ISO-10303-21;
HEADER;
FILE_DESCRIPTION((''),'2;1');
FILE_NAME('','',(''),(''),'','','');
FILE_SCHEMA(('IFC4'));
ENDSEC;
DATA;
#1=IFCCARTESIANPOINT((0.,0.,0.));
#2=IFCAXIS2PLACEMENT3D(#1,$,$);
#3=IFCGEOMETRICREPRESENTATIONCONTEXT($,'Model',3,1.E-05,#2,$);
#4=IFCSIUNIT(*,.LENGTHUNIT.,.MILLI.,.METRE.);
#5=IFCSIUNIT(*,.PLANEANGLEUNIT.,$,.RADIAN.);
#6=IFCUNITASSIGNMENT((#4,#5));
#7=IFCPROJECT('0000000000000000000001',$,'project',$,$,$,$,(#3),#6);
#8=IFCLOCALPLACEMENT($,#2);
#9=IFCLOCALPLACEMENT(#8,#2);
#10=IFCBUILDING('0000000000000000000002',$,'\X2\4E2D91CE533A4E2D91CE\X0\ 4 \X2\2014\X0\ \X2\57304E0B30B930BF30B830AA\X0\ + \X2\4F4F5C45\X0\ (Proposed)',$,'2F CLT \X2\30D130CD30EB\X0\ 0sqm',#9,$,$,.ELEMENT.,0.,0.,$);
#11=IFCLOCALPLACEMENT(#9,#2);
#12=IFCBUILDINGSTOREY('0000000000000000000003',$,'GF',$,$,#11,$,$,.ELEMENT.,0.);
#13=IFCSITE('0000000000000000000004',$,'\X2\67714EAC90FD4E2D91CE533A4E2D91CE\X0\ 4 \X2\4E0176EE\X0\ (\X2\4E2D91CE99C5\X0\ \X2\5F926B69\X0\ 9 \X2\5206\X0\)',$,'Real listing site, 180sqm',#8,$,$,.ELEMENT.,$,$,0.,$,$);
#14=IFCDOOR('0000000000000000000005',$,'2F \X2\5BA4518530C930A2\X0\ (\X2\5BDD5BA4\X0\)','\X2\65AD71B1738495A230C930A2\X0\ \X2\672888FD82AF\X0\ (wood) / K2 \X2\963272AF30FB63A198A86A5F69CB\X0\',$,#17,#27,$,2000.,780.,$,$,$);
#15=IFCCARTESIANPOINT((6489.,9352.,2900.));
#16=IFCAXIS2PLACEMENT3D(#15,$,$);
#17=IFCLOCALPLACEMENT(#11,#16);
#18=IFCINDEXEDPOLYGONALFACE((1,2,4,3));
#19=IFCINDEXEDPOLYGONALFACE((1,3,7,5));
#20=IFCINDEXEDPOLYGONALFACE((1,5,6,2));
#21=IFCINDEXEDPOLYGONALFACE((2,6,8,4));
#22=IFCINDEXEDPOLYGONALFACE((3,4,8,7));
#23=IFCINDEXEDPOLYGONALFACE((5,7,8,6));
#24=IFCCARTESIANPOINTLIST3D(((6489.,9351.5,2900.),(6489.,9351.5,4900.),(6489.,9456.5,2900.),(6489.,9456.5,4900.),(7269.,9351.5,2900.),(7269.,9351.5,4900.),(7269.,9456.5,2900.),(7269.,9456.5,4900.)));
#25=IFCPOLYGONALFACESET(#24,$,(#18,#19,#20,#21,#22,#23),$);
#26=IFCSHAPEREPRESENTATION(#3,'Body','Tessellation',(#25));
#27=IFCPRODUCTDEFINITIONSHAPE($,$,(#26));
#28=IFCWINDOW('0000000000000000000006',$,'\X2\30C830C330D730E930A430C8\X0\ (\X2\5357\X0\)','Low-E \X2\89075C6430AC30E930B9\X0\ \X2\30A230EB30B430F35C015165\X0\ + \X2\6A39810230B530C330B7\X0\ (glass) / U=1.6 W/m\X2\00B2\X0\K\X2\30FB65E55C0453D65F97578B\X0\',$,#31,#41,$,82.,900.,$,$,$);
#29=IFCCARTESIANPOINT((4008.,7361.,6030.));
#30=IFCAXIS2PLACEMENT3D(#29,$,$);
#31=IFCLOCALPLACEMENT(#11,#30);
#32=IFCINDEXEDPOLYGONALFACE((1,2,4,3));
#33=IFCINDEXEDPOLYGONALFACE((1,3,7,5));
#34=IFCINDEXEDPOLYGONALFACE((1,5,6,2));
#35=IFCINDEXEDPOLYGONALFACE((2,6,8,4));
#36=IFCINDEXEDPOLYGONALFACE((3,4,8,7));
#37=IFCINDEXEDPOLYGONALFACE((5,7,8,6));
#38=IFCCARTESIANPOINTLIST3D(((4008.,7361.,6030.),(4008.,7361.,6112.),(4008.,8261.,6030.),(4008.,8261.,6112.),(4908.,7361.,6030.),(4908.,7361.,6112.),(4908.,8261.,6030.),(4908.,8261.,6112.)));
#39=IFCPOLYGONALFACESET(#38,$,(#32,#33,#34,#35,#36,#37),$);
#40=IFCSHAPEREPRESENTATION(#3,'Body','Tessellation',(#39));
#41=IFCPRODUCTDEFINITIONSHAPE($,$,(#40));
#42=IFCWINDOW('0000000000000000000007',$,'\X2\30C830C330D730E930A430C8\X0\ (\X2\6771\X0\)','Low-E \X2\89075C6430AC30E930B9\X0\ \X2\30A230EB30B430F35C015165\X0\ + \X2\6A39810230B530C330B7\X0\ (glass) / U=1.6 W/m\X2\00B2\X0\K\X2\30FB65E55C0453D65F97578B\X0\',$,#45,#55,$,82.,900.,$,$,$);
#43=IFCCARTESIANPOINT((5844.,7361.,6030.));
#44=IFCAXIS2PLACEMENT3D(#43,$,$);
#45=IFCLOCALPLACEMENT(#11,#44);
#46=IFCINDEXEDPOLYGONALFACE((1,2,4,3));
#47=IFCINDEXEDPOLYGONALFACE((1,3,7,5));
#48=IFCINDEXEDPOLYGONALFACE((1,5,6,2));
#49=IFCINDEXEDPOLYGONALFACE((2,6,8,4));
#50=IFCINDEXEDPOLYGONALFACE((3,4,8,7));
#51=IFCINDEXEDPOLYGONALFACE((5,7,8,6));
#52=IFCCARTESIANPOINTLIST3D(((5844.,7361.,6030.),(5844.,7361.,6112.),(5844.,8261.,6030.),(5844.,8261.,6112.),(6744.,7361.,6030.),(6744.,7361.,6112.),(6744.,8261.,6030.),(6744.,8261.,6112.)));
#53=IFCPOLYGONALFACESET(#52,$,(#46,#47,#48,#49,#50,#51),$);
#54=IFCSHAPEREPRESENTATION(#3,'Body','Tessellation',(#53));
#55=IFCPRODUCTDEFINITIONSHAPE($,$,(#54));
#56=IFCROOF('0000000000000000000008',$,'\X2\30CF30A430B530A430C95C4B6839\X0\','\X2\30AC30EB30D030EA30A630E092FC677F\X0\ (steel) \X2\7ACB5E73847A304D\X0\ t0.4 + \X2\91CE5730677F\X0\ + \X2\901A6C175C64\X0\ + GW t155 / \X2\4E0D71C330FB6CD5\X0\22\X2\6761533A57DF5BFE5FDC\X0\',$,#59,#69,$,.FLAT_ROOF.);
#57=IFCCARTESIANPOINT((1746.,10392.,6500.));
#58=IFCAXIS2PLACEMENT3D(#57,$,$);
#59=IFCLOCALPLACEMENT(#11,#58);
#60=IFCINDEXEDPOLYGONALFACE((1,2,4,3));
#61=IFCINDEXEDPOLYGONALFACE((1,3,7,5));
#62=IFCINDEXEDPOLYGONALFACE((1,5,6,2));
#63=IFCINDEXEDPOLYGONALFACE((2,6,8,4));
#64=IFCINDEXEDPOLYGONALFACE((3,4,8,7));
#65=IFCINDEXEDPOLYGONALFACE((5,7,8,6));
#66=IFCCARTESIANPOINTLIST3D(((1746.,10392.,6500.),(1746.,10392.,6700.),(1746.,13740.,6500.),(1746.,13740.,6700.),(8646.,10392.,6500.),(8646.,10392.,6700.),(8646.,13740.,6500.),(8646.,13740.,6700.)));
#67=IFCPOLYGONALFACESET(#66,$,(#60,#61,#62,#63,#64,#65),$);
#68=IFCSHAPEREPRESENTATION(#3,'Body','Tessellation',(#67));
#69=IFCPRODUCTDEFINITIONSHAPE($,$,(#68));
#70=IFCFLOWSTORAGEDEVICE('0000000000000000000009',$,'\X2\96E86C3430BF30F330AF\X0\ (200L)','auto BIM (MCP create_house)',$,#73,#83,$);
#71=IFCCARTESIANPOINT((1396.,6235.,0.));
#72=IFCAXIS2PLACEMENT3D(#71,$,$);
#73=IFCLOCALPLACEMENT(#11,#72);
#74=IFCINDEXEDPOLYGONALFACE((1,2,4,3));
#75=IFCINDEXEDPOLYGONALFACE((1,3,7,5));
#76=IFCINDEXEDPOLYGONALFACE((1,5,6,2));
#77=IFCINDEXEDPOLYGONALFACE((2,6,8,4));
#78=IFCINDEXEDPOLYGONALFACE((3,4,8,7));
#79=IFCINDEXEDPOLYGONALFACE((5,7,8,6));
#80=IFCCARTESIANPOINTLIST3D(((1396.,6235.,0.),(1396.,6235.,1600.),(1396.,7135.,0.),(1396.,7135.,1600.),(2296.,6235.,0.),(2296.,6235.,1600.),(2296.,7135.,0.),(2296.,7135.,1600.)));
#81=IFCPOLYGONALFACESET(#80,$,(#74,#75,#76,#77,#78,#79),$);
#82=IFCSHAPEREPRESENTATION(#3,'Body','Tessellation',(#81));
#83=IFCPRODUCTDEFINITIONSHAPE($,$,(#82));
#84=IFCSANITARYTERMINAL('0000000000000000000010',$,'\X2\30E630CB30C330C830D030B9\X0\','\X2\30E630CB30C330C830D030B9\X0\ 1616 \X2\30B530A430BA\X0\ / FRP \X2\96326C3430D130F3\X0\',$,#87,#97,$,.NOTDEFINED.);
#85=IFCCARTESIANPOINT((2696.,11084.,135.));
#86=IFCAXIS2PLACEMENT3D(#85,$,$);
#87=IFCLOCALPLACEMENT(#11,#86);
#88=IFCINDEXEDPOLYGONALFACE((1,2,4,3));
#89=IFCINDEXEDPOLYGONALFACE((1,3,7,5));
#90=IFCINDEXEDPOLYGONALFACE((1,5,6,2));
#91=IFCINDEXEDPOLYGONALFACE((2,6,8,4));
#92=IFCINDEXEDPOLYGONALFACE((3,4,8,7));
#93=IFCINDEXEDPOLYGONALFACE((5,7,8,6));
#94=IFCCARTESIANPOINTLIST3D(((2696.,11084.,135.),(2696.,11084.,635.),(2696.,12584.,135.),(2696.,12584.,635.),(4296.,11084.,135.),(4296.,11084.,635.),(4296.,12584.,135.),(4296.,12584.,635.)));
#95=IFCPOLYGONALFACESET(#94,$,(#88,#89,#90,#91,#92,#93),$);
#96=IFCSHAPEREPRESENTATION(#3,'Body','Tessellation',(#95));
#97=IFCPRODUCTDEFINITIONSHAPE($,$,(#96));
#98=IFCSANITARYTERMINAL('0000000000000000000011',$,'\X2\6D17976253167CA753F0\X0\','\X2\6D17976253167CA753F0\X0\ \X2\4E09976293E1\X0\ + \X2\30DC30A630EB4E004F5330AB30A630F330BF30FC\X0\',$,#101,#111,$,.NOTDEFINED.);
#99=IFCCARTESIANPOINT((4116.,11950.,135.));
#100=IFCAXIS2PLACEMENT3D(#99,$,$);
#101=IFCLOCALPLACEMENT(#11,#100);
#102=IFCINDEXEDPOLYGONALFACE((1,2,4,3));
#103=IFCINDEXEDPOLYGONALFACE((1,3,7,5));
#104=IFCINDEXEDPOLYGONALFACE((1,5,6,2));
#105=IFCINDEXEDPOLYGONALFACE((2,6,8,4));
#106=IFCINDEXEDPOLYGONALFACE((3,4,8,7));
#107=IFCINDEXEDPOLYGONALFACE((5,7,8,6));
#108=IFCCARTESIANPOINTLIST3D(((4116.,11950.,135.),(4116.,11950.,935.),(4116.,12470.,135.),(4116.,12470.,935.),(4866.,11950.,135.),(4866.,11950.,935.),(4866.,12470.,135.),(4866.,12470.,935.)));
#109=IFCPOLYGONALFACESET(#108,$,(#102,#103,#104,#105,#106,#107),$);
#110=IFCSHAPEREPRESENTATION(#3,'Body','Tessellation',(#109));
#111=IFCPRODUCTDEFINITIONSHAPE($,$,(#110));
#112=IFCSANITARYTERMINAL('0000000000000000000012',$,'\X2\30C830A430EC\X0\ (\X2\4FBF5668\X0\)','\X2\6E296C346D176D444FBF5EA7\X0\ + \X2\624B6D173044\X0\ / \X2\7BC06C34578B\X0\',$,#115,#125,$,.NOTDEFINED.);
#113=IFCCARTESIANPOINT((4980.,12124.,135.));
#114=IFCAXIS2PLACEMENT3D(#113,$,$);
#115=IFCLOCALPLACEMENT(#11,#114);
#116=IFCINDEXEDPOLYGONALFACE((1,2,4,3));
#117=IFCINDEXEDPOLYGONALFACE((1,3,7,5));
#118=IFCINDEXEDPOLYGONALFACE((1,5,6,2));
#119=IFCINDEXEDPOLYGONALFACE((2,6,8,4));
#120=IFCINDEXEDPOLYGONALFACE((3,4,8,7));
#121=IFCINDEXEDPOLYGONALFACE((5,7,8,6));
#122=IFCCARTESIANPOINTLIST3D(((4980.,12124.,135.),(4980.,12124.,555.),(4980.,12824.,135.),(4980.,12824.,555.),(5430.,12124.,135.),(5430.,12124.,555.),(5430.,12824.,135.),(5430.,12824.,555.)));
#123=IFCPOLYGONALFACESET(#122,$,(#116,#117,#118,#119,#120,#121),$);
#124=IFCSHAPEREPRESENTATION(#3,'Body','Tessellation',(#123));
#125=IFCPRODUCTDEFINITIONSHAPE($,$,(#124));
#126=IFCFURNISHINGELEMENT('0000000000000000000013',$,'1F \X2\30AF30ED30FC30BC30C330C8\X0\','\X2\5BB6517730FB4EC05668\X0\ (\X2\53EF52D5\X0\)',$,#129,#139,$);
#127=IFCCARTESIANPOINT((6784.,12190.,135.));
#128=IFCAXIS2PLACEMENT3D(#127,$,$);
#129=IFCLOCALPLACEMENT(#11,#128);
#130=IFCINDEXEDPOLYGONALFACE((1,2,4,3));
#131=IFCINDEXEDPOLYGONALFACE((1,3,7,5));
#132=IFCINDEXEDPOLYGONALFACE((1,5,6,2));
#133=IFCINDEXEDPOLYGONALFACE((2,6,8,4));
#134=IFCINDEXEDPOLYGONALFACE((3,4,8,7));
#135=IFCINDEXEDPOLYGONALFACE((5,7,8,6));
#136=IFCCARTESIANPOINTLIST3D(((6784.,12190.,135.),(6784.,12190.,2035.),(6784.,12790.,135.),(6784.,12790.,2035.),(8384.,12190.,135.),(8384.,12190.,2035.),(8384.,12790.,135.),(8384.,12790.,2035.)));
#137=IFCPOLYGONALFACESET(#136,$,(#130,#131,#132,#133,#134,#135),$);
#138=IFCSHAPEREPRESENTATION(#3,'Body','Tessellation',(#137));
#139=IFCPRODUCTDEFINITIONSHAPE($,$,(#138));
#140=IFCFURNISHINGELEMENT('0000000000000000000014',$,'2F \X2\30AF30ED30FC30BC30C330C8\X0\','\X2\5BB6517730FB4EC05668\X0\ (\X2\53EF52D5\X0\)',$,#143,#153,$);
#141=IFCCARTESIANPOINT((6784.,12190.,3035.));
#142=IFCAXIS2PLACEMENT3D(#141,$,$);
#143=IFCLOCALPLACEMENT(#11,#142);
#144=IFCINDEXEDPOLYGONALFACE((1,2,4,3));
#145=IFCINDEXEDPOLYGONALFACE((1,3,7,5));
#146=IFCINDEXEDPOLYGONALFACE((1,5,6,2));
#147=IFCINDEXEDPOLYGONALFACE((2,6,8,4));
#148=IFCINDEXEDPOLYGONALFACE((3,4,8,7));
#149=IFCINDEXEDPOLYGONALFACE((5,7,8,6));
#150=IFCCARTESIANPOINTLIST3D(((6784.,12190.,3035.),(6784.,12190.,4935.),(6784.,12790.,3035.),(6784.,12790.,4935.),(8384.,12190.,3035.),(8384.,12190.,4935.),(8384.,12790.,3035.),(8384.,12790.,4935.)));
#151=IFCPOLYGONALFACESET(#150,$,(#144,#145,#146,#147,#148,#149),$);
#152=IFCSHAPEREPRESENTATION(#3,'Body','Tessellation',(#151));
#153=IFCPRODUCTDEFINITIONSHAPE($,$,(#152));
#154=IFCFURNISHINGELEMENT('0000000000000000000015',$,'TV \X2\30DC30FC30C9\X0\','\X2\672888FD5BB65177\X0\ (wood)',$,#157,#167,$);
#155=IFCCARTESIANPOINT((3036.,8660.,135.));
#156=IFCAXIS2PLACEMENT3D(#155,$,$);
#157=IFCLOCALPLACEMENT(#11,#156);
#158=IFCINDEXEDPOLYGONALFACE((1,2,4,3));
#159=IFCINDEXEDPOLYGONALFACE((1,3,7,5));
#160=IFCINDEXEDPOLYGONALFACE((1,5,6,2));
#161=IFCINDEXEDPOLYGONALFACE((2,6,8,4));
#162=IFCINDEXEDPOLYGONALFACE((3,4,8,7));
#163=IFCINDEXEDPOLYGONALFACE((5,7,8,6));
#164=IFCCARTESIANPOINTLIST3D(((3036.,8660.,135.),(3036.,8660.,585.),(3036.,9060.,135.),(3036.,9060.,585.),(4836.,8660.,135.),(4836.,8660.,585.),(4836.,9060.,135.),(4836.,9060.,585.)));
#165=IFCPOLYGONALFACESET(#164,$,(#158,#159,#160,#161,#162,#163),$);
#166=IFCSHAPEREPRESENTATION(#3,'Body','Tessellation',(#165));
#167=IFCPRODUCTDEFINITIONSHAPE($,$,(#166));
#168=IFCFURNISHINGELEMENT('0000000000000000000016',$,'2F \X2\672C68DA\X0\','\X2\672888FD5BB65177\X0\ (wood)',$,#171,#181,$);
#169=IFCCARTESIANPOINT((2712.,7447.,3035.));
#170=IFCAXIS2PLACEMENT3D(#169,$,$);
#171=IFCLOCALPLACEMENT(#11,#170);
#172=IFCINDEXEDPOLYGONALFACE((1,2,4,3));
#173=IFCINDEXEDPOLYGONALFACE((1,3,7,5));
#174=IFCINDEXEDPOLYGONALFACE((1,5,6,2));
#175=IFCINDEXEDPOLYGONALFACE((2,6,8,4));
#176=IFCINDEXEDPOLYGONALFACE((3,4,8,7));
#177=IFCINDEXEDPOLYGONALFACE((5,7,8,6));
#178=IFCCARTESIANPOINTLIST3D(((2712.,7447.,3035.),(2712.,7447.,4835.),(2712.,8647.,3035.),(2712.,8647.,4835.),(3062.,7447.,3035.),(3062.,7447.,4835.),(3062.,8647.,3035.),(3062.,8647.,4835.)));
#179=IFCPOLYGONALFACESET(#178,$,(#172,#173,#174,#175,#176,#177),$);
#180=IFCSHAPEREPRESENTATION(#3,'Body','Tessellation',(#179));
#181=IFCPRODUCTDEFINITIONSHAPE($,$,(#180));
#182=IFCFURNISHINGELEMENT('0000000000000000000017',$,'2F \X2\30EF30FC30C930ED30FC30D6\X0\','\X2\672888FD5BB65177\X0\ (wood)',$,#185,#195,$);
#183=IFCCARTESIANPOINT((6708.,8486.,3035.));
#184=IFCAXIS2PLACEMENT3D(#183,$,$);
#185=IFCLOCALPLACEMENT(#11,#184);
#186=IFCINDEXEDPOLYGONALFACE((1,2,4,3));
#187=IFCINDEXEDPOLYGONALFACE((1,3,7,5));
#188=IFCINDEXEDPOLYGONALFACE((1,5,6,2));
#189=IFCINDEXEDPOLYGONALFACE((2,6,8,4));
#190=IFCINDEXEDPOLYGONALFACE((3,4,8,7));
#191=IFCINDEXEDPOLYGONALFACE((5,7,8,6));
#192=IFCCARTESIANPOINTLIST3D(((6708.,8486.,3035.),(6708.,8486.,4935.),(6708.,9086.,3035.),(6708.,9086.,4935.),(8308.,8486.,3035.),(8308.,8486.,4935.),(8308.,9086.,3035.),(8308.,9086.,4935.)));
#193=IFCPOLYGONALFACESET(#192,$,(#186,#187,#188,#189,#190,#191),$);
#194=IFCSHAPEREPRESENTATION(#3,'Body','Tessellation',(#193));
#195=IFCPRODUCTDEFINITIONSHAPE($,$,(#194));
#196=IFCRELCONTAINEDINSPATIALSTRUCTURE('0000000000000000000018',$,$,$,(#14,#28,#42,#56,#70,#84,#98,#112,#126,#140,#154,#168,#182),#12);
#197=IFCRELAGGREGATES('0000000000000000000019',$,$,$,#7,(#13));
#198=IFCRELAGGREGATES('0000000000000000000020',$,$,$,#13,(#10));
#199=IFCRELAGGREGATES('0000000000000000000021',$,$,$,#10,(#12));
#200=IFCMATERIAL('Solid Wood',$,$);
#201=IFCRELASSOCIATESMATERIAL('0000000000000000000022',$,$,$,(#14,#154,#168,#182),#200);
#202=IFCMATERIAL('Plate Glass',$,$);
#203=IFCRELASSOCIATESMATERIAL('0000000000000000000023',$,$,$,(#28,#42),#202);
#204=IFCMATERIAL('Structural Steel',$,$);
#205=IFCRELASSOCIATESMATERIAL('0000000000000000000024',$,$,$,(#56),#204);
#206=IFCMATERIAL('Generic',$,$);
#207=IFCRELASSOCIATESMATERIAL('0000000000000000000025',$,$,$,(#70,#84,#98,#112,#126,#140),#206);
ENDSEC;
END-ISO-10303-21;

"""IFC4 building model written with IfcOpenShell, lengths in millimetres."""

from ifc_helpers import new_model, si_unit, frame, frame_2d, origin, place, context, project, spatial, rectangle, extrude, material, element, save


model = new_model("IFC4")

# Units and contexts
model_context = context("Model", 3, precision=1e-05, world=origin())
ifc_project = project(units=[si_unit("LENGTHUNIT", "METRE", prefix="MILLI"), si_unit("PLANEANGLEUNIT", "RADIAN")], contexts=[model_context])

# Site, building, storey
site_placement = place(None, origin())
site = spatial("IfcSite", under=ifc_project, at=site_placement, Name="東京都中野区中野 4 丁目 (中野駅 徒歩 9 分)", ObjectType="Real listing site, 180sqm", CompositionType="ELEMENT", RefElevation=0.0)
building_placement = place(site_placement, origin())
building = spatial("IfcBuilding", under=site, at=building_placement, Name="中野区中野 4 — 地下スタジオ + 住居 (Proposed)", ObjectType="2F CLT パネル 0sqm", CompositionType="ELEMENT", ElevationOfRefHeight=0.0, ElevationOfTerrain=0.0)
storey_placement = place(building_placement, origin())
storey = spatial("IfcBuildingStorey", under=building, at=storey_placement, Name="GF", CompositionType="ELEMENT", Elevation=0.0)

# Shared definitions
ifc_material_1 = material(Name="Solid Wood")
ifc_material_2 = material(Name="Plate Glass")

# Door
door_1_placement = place(storey_placement, frame((6489.0, 9352.0, 2900.0)))
element("IfcDoor", 1, at=door_1_placement, inside=storey, material=ifc_material_1, Name="2F 室内ドア (寝室)", Description="断熱玄関ドア 木製芯 (wood) / K2 防犯・採風機構", OverallHeight=2000.0, OverallWidth=780.0, context=model_context, shape_type="SweptSolid", body=[
    extrude(rectangle(XDim=780.0, YDim=105.0, at=frame_2d((390.0, 52.0))), frame((6489.0, 9352.0, 2900.0)), (0.0, 0.0, 1.0), 2000.0),
])

# Windows
window_1_placement = place(storey_placement, frame((4008.0, 7361.0, 6030.0)))
element("IfcWindow", 2, at=window_1_placement, inside=storey, material=ifc_material_2, Name="トップライト (南)", Description="Low-E 複層ガラス アルゴン封入 + 樹脂サッシ (glass) / U=1.6 W/m²K・日射取得型", OverallHeight=82.0, OverallWidth=900.0, context=model_context, shape_type="SweptSolid", body=[
    extrude(rectangle(XDim=900.0, YDim=900.0, at=frame_2d((450.0, 450.0))), frame((4008.0, 7361.0, 6030.0)), (0.0, 0.0, 1.0), 82.0),
])
window_2_placement = place(storey_placement, frame((5844.0, 7361.0, 6030.0)))
element("IfcWindow", 3, at=window_2_placement, inside=storey, material=ifc_material_2, Name="トップライト (東)", Description="Low-E 複層ガラス アルゴン封入 + 樹脂サッシ (glass) / U=1.6 W/m²K・日射取得型", OverallHeight=82.0, OverallWidth=900.0, context=model_context, shape_type="SweptSolid", body=[
    extrude(rectangle(XDim=900.0, YDim=900.0, at=frame_2d((450.0, 450.0))), frame((5844.0, 7361.0, 6030.0)), (0.0, 0.0, 1.0), 82.0),
])

# Roof
ifc_material_3 = material(Name="Structural Steel")
roof_placement = place(storey_placement, frame((1746.0, 10392.0, 6500.0)))
element("IfcRoof", 4, at=roof_placement, inside=storey, material=ifc_material_3, Name="ハイサイド屋根", Description="ガルバリウム鋼板 (steel) 立平葺き t0.4 + 野地板 + 通気層 + GW t155 / 不燃・法22条区域対応", PredefinedType="FLAT_ROOF", context=model_context, shape_type="SweptSolid", body=[
    extrude(rectangle(XDim=6900.0, YDim=3348.0, at=frame_2d((3450.0, 1674.0))), frame((1746.0, 10392.0, 6500.0)), (0.0, 0.0, 1.0), 200.0),
])

# Flow storage device
ifc_material_4 = material(Name="Generic")
flow_storage_device_placement = place(storey_placement, frame((1396.0, 6235.0, 0.0)))
element("IfcFlowStorageDevice", 5, at=flow_storage_device_placement, inside=storey, material=ifc_material_4, Name="雨水タンク (200L)", Description="auto BIM (MCP create_house)", context=model_context, shape_type="SweptSolid", body=[
    extrude(rectangle(XDim=900.0, YDim=900.0, at=frame_2d((450.0, 450.0))), frame((1396.0, 6235.0, 0.0)), (0.0, 0.0, 1.0), 1600.0),
])

# Sanitary terminals
sanitary_terminal_1_placement = place(storey_placement, frame((2696.0, 11084.0, 135.0)))
element("IfcSanitaryTerminal", 6, at=sanitary_terminal_1_placement, inside=storey, material=ifc_material_4, Name="ユニットバス", Description="ユニットバス 1616 サイズ / FRP 防水パン", PredefinedType="NOTDEFINED", context=model_context, shape_type="SweptSolid", body=[
    extrude(rectangle(XDim=1600.0, YDim=1500.0, at=frame_2d((800.0, 750.0))), frame((2696.0, 11084.0, 135.0)), (0.0, 0.0, 1.0), 500.0),
])
sanitary_terminal_2_placement = place(storey_placement, frame((4116.0, 11950.0, 135.0)))
element("IfcSanitaryTerminal", 7, at=sanitary_terminal_2_placement, inside=storey, material=ifc_material_4, Name="洗面化粧台", Description="洗面化粧台 三面鏡 + ボウル一体カウンター", PredefinedType="NOTDEFINED", context=model_context, shape_type="SweptSolid", body=[
    extrude(rectangle(XDim=750.0, YDim=520.0, at=frame_2d((375.0, 260.0))), frame((4116.0, 11950.0, 135.0)), (0.0, 0.0, 1.0), 800.0),
])
sanitary_terminal_3_placement = place(storey_placement, frame((4980.0, 12124.0, 135.0)))
element("IfcSanitaryTerminal", 8, at=sanitary_terminal_3_placement, inside=storey, material=ifc_material_4, Name="トイレ (便器)", Description="温水洗浄便座 + 手洗い / 節水型", PredefinedType="NOTDEFINED", context=model_context, shape_type="SweptSolid", body=[
    extrude(rectangle(XDim=450.0, YDim=700.0, at=frame_2d((225.0, 350.0))), frame((4980.0, 12124.0, 135.0)), (0.0, 0.0, 1.0), 420.0),
])

# Furnishing elements
furnishing_1_placement = place(storey_placement, frame((6784.0, 12190.0, 135.0)))
element("IfcFurnishingElement", 9, at=furnishing_1_placement, inside=storey, material=ifc_material_4, Name="1F クローゼット", Description="家具・什器 (可動)", context=model_context, shape_type="SweptSolid", body=[
    extrude(rectangle(XDim=1600.0, YDim=600.0, at=frame_2d((800.0, 300.0))), frame((6784.0, 12190.0, 135.0)), (0.0, 0.0, 1.0), 1900.0),
])
furnishing_2_placement = place(storey_placement, frame((6784.0, 12190.0, 3035.0)))
element("IfcFurnishingElement", 10, at=furnishing_2_placement, inside=storey, material=ifc_material_4, Name="2F クローゼット", Description="家具・什器 (可動)", context=model_context, shape_type="SweptSolid", body=[
    extrude(rectangle(XDim=1600.0, YDim=600.0, at=frame_2d((800.0, 300.0))), frame((6784.0, 12190.0, 3035.0)), (0.0, 0.0, 1.0), 1900.0),
])
furnishing_3_placement = place(storey_placement, frame((3036.0, 8660.0, 135.0)))
element("IfcFurnishingElement", 11, at=furnishing_3_placement, inside=storey, material=ifc_material_1, Name="TV ボード", Description="木製家具 (wood)", context=model_context, shape_type="SweptSolid", body=[
    extrude(rectangle(XDim=1800.0, YDim=400.0, at=frame_2d((900.0, 200.0))), frame((3036.0, 8660.0, 135.0)), (0.0, 0.0, 1.0), 450.0),
])
furnishing_4_placement = place(storey_placement, frame((2712.0, 7447.0, 3035.0)))
element("IfcFurnishingElement", 12, at=furnishing_4_placement, inside=storey, material=ifc_material_1, Name="2F 本棚", Description="木製家具 (wood)", context=model_context, shape_type="SweptSolid", body=[
    extrude(rectangle(XDim=350.0, YDim=1200.0, at=frame_2d((175.0, 600.0))), frame((2712.0, 7447.0, 3035.0)), (0.0, 0.0, 1.0), 1800.0),
])
furnishing_5_placement = place(storey_placement, frame((6708.0, 8486.0, 3035.0)))
element("IfcFurnishingElement", 13, at=furnishing_5_placement, inside=storey, material=ifc_material_1, Name="2F ワードローブ", Description="木製家具 (wood)", context=model_context, shape_type="SweptSolid", body=[
    extrude(rectangle(XDim=1600.0, YDim=600.0, at=frame_2d((800.0, 300.0))), frame((6708.0, 8486.0, 3035.0)), (0.0, 0.0, 1.0), 1900.0),
])

save(model, "model.ifc")
